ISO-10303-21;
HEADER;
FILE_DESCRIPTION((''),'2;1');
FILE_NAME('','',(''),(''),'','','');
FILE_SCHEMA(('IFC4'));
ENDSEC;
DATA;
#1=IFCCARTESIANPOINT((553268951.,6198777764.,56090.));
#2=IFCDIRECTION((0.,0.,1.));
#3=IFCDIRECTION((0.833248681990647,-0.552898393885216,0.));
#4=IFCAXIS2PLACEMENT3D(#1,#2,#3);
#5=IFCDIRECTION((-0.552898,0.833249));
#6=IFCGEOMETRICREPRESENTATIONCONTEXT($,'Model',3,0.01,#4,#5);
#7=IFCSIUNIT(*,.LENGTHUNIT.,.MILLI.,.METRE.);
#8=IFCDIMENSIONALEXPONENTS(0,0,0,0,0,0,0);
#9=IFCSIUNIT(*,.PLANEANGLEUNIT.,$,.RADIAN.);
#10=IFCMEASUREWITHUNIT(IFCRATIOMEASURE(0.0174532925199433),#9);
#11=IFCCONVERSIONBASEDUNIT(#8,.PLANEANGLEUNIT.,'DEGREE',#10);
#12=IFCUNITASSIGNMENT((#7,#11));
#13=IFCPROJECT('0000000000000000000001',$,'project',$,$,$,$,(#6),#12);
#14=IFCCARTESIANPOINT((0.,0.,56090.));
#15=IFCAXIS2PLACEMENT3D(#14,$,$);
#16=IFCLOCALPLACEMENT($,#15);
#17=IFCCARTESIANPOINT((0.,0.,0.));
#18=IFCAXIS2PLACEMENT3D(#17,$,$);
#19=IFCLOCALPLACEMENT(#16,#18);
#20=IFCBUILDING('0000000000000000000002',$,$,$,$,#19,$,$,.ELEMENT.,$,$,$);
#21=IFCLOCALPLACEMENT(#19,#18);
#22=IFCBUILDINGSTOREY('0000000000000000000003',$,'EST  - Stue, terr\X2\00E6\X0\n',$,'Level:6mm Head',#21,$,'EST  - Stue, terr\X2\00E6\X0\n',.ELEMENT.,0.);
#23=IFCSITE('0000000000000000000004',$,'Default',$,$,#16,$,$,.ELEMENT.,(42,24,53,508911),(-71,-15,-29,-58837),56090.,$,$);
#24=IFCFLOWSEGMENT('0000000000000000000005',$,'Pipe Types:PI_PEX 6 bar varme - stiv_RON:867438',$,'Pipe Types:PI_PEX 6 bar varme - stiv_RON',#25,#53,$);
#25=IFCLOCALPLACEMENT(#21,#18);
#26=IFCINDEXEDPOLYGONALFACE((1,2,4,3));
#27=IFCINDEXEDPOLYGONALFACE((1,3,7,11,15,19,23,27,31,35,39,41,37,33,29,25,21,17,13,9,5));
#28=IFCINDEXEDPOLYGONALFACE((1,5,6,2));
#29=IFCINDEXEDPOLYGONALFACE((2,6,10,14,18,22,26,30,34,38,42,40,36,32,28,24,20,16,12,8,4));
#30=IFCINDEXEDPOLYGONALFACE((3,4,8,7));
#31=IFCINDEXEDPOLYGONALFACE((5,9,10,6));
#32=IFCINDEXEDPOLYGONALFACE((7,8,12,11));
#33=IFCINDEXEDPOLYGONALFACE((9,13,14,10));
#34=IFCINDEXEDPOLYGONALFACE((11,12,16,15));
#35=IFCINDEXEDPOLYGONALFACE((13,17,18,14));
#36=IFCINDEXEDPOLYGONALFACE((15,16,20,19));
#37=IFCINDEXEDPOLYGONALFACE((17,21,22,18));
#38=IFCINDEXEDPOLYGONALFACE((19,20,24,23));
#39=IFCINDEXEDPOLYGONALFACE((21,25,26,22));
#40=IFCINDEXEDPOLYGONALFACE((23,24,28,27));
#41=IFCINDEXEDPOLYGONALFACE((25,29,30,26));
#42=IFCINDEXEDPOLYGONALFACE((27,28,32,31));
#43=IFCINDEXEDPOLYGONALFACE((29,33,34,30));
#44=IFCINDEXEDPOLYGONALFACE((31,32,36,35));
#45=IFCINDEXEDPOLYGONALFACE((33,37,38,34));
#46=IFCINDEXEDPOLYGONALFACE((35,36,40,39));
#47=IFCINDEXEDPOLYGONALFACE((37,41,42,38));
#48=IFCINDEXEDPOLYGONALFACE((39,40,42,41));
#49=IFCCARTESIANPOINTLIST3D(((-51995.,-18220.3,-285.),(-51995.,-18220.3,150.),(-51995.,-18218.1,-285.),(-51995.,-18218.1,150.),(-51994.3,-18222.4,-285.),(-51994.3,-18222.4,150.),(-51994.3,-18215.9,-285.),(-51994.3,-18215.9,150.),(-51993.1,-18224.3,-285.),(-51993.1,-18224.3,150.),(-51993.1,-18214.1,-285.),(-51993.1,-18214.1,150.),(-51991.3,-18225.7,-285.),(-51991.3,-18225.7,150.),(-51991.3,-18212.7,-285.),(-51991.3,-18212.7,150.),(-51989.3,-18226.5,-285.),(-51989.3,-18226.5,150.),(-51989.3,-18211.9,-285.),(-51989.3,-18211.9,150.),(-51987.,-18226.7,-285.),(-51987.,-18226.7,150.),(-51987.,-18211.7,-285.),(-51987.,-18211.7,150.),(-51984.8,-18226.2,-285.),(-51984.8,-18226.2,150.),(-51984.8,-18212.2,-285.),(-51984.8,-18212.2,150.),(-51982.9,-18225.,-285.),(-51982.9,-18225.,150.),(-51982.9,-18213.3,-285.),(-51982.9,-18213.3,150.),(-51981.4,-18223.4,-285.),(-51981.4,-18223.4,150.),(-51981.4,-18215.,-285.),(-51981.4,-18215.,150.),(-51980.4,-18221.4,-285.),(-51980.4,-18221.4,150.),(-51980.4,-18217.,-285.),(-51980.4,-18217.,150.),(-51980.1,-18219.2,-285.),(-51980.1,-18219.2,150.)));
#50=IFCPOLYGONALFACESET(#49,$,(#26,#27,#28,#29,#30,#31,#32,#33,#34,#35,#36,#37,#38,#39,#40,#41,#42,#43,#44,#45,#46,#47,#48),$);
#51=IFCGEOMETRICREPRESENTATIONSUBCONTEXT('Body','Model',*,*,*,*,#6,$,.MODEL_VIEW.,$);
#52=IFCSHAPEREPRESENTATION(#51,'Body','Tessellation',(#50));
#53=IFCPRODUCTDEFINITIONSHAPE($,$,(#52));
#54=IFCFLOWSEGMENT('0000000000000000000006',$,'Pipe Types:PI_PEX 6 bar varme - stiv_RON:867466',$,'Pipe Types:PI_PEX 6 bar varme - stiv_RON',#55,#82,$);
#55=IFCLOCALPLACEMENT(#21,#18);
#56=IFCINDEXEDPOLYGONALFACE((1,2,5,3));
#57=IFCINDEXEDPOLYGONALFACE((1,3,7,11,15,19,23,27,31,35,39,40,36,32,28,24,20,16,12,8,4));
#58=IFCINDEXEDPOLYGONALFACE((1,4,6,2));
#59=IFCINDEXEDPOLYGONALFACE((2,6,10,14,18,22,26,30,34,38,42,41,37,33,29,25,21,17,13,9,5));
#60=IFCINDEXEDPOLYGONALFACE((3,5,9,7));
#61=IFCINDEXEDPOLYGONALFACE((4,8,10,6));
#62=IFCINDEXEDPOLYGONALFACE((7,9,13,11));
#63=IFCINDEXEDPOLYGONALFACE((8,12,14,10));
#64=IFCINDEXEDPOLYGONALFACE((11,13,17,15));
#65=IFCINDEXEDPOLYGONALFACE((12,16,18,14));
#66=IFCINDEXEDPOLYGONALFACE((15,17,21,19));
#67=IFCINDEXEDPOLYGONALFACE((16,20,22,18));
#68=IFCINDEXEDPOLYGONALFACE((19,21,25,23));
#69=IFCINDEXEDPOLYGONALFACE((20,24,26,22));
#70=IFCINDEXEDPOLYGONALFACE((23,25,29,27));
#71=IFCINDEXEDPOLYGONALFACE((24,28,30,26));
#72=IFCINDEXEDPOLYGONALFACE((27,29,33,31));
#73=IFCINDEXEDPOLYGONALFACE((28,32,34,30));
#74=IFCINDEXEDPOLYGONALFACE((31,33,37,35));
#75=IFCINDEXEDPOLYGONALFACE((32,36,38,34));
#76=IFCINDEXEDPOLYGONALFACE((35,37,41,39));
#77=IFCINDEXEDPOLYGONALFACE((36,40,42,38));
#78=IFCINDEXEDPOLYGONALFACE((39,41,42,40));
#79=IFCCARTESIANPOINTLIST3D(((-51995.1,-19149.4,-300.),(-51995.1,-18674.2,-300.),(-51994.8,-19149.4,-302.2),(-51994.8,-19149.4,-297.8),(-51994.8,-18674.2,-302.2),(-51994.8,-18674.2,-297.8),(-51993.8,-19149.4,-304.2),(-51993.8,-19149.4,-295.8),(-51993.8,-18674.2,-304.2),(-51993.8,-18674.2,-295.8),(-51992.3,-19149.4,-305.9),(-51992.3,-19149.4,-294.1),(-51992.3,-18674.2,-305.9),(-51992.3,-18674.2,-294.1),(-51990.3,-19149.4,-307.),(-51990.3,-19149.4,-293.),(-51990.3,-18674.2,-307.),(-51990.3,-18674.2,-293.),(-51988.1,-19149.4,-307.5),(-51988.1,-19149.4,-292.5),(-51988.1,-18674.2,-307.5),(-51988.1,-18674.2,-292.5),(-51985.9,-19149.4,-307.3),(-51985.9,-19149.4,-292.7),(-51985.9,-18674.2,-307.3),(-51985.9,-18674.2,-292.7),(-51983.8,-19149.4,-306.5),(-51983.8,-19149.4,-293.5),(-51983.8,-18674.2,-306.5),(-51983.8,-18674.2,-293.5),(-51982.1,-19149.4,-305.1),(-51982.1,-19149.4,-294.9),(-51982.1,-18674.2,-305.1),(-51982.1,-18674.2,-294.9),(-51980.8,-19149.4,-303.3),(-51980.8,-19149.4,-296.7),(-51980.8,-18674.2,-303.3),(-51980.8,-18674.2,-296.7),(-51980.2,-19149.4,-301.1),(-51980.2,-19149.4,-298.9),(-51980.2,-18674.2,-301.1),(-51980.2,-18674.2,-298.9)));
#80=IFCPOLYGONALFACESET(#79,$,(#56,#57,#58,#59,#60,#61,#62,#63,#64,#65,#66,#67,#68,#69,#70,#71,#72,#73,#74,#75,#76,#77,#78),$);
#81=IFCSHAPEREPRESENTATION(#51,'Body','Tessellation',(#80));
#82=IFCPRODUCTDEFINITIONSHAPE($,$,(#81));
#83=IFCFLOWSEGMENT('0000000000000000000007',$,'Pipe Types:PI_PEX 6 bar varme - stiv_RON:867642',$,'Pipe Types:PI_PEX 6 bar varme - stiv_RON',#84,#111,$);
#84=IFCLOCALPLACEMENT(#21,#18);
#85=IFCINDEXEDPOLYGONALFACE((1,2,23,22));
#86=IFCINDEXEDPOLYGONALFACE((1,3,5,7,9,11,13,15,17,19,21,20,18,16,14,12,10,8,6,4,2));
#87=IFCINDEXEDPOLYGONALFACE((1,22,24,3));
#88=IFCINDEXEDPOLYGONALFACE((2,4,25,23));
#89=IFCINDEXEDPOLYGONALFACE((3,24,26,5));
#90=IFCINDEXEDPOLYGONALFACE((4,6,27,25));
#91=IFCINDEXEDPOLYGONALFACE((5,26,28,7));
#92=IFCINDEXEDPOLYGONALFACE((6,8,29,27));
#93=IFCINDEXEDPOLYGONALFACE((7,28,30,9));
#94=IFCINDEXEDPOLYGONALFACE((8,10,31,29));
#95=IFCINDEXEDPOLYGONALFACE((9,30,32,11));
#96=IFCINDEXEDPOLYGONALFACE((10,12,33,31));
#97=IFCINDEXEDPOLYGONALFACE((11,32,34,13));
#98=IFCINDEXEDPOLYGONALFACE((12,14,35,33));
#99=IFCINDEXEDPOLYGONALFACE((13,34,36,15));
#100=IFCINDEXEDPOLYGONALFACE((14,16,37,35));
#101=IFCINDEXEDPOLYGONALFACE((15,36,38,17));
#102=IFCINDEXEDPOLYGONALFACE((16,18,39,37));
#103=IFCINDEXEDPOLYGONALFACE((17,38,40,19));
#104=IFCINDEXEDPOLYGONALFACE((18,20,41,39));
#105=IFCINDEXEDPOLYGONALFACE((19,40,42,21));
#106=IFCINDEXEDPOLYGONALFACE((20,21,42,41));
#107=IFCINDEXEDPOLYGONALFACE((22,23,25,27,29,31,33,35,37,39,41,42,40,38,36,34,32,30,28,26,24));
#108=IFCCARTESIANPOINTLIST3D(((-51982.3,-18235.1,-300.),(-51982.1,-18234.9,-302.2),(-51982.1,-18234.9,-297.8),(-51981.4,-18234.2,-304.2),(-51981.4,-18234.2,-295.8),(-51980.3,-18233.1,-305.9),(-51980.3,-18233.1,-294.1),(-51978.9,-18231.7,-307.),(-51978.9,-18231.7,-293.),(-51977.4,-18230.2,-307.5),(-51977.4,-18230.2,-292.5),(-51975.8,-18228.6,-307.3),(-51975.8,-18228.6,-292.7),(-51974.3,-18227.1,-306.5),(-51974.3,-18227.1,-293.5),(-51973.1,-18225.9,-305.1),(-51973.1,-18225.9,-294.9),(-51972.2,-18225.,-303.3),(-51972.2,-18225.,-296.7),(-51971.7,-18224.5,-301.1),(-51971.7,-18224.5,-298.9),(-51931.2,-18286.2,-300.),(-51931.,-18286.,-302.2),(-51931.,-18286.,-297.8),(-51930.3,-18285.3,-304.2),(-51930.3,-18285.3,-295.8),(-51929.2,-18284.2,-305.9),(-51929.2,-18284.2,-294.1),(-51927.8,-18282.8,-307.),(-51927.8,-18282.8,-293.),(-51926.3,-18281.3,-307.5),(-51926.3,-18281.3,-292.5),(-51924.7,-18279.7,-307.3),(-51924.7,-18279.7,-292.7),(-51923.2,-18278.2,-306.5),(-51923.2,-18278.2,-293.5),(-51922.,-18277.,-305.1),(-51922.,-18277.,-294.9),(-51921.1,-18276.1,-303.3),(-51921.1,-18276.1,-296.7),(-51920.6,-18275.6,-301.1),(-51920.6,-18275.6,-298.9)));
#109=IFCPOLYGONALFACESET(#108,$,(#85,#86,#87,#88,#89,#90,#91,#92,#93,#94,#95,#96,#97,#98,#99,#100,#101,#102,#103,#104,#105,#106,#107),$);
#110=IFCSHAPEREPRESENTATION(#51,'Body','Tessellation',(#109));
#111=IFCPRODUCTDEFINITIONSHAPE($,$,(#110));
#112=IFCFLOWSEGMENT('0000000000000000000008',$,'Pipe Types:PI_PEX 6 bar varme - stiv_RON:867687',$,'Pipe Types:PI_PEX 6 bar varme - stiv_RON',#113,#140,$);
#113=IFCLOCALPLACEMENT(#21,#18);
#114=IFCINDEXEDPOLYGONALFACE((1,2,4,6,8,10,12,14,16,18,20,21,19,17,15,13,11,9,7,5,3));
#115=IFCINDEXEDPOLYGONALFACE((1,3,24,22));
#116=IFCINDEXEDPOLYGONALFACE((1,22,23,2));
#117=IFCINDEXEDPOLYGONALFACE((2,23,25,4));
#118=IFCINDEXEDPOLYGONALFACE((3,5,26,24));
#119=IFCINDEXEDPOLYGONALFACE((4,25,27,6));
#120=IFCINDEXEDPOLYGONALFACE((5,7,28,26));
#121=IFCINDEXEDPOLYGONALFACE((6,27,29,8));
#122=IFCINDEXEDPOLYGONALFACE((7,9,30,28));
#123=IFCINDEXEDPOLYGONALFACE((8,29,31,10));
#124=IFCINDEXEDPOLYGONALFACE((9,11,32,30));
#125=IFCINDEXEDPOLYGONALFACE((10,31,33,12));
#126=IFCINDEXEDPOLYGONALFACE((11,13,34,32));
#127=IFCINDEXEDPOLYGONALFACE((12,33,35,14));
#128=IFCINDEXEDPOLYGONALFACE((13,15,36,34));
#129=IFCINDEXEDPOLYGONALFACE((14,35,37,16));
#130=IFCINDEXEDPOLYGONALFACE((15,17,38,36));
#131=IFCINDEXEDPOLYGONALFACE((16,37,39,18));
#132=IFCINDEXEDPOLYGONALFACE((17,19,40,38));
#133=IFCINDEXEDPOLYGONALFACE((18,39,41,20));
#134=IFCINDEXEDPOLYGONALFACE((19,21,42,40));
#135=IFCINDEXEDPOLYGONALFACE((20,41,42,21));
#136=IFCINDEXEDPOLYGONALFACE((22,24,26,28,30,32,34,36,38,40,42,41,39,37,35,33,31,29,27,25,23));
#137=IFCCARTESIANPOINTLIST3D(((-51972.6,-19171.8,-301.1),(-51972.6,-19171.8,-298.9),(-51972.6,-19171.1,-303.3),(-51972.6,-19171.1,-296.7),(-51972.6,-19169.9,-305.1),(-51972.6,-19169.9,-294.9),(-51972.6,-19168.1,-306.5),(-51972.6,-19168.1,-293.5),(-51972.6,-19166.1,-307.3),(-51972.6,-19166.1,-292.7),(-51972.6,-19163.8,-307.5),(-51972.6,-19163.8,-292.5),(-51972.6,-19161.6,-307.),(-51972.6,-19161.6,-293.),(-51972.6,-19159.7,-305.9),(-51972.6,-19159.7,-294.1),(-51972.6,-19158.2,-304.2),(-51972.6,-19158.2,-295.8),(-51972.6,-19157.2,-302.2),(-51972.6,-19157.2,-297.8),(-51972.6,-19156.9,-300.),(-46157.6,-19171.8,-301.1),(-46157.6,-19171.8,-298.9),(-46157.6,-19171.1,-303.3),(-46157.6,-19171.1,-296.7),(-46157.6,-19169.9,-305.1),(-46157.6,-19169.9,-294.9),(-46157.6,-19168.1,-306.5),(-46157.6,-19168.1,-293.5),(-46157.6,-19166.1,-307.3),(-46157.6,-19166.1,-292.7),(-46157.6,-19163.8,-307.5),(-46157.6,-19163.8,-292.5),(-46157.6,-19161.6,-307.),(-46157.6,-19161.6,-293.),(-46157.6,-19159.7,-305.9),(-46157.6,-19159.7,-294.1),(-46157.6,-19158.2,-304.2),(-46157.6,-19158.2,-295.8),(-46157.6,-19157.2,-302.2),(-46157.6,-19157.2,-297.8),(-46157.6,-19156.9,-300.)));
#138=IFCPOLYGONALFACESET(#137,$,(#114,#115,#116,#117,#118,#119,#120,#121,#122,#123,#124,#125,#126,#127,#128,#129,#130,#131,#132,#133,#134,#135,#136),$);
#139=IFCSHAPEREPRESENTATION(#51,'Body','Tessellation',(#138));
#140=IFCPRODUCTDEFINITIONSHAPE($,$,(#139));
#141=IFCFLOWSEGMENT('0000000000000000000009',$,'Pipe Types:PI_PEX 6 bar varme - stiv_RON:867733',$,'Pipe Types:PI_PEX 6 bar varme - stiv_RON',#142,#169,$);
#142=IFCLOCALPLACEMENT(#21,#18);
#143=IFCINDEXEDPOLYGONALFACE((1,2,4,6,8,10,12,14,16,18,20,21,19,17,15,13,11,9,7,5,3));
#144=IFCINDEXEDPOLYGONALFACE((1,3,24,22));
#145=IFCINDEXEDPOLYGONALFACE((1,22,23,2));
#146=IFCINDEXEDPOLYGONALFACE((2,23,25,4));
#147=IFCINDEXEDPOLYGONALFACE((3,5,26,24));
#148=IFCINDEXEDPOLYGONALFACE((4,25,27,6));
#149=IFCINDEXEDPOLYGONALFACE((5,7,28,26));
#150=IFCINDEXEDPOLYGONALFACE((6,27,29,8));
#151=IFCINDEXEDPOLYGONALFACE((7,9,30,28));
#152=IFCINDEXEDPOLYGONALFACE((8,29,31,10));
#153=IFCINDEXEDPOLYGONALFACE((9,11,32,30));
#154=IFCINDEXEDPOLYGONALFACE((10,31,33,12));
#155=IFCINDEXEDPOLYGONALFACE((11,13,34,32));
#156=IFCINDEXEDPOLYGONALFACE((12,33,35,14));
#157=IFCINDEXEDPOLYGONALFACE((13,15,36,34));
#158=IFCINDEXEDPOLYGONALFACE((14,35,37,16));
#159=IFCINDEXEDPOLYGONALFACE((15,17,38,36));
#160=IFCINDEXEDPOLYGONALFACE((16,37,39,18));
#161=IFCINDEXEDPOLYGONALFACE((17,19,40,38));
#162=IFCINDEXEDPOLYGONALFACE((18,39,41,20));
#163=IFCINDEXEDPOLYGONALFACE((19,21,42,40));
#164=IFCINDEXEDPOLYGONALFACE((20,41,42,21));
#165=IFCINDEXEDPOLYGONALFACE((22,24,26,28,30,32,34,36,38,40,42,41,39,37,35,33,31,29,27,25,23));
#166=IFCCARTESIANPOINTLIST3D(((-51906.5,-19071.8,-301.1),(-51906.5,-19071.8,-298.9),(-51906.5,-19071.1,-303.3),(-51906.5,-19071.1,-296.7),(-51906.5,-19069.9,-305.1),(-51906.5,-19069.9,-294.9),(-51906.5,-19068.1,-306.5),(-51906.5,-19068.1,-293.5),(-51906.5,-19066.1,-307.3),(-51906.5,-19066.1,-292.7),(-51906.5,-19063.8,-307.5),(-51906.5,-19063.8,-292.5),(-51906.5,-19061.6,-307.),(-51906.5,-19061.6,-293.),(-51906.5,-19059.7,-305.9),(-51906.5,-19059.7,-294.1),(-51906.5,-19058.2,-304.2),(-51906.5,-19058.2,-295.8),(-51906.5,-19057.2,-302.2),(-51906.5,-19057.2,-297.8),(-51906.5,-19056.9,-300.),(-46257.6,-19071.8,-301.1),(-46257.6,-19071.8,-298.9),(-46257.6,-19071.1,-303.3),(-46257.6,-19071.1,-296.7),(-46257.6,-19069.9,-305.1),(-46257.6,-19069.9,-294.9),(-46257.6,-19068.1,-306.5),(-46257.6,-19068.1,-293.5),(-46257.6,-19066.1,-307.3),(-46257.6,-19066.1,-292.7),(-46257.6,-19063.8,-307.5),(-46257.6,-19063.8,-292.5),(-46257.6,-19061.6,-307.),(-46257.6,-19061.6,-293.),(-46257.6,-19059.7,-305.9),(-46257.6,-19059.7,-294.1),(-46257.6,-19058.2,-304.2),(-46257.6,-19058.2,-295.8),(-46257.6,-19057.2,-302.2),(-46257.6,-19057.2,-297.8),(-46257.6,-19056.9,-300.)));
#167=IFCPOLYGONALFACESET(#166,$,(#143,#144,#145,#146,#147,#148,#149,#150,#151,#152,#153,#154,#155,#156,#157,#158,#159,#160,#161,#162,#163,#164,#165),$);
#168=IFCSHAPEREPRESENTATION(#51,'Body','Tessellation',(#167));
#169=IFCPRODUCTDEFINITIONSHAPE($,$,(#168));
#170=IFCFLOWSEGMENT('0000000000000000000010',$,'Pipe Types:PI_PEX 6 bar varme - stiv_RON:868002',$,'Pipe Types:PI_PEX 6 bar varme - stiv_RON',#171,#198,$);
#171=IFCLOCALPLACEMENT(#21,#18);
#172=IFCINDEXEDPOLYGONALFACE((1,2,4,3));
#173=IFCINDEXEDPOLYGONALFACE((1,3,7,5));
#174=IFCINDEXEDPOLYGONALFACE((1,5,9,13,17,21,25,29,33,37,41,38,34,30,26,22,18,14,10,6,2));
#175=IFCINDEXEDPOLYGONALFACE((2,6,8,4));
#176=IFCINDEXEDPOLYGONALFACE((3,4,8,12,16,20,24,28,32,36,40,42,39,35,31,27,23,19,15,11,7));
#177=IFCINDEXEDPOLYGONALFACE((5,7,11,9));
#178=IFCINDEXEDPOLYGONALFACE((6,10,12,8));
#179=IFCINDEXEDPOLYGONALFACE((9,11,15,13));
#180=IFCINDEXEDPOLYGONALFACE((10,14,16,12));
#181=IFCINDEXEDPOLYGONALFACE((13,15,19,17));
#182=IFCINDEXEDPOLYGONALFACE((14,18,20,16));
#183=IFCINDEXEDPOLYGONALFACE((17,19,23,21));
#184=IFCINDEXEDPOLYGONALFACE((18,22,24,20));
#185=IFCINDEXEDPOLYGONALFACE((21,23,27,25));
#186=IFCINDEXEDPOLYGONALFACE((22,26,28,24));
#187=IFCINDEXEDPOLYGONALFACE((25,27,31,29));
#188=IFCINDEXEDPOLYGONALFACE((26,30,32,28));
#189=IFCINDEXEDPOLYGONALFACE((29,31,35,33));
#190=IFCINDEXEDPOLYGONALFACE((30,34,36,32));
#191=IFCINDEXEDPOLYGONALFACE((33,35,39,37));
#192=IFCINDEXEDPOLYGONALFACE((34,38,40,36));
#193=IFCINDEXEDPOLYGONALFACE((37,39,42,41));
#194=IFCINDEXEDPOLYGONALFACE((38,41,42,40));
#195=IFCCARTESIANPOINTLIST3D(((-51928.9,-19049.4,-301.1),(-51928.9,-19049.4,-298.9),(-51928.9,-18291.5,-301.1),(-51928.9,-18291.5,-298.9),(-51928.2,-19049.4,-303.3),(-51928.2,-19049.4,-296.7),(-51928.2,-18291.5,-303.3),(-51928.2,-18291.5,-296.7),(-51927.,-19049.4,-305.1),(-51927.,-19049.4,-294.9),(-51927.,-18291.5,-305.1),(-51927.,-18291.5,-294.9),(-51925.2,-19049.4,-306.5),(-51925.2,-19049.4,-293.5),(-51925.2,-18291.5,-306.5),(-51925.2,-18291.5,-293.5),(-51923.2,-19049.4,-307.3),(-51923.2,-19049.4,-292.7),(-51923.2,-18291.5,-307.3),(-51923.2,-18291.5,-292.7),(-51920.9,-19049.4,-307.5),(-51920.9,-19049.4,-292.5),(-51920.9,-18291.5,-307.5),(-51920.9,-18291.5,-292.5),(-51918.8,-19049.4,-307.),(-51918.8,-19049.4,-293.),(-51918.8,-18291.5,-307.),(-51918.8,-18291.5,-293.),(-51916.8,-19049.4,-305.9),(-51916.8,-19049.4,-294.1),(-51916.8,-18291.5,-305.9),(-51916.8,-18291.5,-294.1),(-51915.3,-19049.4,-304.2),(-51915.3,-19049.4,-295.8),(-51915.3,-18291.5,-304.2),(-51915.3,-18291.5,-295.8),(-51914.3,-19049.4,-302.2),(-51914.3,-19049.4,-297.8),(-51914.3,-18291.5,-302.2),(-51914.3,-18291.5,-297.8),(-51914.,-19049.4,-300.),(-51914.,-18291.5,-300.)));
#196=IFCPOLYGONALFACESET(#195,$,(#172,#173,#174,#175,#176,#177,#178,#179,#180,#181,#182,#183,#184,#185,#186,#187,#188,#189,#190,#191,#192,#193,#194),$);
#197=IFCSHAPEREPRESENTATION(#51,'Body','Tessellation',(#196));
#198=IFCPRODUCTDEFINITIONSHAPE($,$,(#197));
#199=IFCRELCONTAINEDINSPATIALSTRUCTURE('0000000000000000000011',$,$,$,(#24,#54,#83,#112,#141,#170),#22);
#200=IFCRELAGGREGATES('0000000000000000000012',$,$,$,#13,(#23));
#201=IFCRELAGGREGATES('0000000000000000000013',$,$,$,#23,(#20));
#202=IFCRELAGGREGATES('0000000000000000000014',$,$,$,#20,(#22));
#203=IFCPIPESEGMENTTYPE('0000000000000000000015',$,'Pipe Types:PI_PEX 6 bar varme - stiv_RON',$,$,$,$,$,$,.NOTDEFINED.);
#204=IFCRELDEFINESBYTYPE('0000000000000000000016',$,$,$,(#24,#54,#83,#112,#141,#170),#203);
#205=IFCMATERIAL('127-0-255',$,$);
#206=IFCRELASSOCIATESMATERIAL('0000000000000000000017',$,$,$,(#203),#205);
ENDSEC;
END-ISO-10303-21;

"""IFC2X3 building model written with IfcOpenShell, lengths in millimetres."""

from ifc_helpers import new_model, entity, si_unit, converted_unit, direction, frame, frame_2d, origin, origin_2d_with_axis, place, context, subcontext, project, spatial, circle, extrude, material, type_object, element, save


model = new_model("IFC2X3")

# Units and contexts
model_context = context("Model", 3, precision=0.01, world=frame((553268951.0, 6198777764.0, 56090.0), z_axis=(0.0, 0.0, 1.0), x_axis=(0.833248681990647, -0.552898393885216, 0.0)), true_north=direction((-0.552898, 0.833249)))
body_context = subcontext(model_context, "Body", "Model", "MODEL_VIEW")
ifc_project = project(units=[si_unit("LENGTHUNIT", "METRE", prefix="MILLI"), converted_unit("PLANEANGLEUNIT", "DEGREE", entity("IfcRatioMeasure", 0.0174532925199433), si_unit("PLANEANGLEUNIT", "RADIAN"), dimensions=[0, 0, 0, 0, 0, 0, 0])], contexts=[model_context])

# Site, building, storey
site_placement = place(None, frame((0.0, 0.0, 56090.0)))
site = spatial("IfcSite", under=ifc_project, at=site_placement, Name="Default", CompositionType="ELEMENT", RefLatitude=(42, 24, 53, 508911), RefLongitude=(-71, -15, -29, -58837), RefElevation=56090.0)
building_placement = place(site_placement, origin())
building = spatial("IfcBuilding", under=site, at=building_placement, CompositionType="ELEMENT")
storey_placement = place(building_placement, frame((0.0, 0.0, 0.0)))
storey = spatial("IfcBuildingStorey", under=building, at=storey_placement, Name="EST  - Stue, terræn", ObjectType="Level:6mm Head", LongName="EST  - Stue, terræn", CompositionType="ELEMENT", Elevation=0.0)

# Flow segments
ifc_material = material(Name="127-0-255")
pipe_segment_type = type_object("IfcPipeSegmentType", Name="Pipe Types:PI_PEX 6 bar varme - stiv_RON", PredefinedType="NOTDEFINED", material=ifc_material)
flow_segment_1_placement = place(storey_placement, origin())
element("IfcFlowSegment", 1, at=flow_segment_1_placement, inside=storey, type_object=pipe_segment_type, Name="Pipe Types:PI_PEX 6 bar varme - stiv_RON:867438", ObjectType="Pipe Types:PI_PEX 6 bar varme - stiv_RON", context=body_context, shape_type="SweptSolid", body=[
    extrude(circle(Radius=7.5, at=origin_2d_with_axis()), frame((-51987.6, -18219.2, -285.0)), (0.0, 0.0, 1.0), 435.0),
])
flow_segment_2_placement = place(storey_placement, origin())
element("IfcFlowSegment", 2, at=flow_segment_2_placement, inside=storey, type_object=pipe_segment_type, Name="Pipe Types:PI_PEX 6 bar varme - stiv_RON:867466", ObjectType="Pipe Types:PI_PEX 6 bar varme - stiv_RON", context=body_context, shape_type="SweptSolid", body=[
    extrude(circle(Radius=7.5, at=frame_2d((0.0, 0.0), x_axis=(1.0, 0.0))), frame((-51987.6, -19149.4, -300.0), z_axis=(0.0, 1.0, 0.0), x_axis=(-1.0, 0.0, 0.0)), (0.0, 0.0, 1.0), 475.2),
])
flow_segment_3_placement = place(storey_placement, origin())
element("IfcFlowSegment", 3, at=flow_segment_3_placement, inside=storey, type_object=pipe_segment_type, Name="Pipe Types:PI_PEX 6 bar varme - stiv_RON:867642", ObjectType="Pipe Types:PI_PEX 6 bar varme - stiv_RON", context=body_context, shape_type="SweptSolid", body=[
    extrude(circle(Radius=7.5, at=origin_2d_with_axis()), frame((-51977.0, -18229.8, -300.0), z_axis=(0.707107, -0.707107, 0.0), x_axis=(-0.707107, -0.707107, 0.0)), (0.0, 0.0, 1.0), 72.3),
])
flow_segment_4_placement = place(storey_placement, origin())
element("IfcFlowSegment", 4, at=flow_segment_4_placement, inside=storey, type_object=pipe_segment_type, Name="Pipe Types:PI_PEX 6 bar varme - stiv_RON:867687", ObjectType="Pipe Types:PI_PEX 6 bar varme - stiv_RON", context=body_context, shape_type="SweptSolid", body=[
    extrude(circle(Radius=7.5, at=frame_2d((0.0, 0.0), x_axis=(1.0, 0.0))), frame((-51972.6, -19164.4, -300.0), z_axis=(1.0, 0.0, 0.0), x_axis=(0.0, 1.0, 0.0)), (0.0, 0.0, 1.0), 5815.0),
])
flow_segment_5_placement = place(storey_placement, origin())
element("IfcFlowSegment", 5, at=flow_segment_5_placement, inside=storey, type_object=pipe_segment_type, Name="Pipe Types:PI_PEX 6 bar varme - stiv_RON:867733", ObjectType="Pipe Types:PI_PEX 6 bar varme - stiv_RON", context=body_context, shape_type="SweptSolid", body=[
    extrude(circle(Radius=7.5, at=origin_2d_with_axis()), frame((-51906.5, -19064.4, -300.0), z_axis=(1.0, 0.0, 0.0), x_axis=(0.0, 1.0, 0.0)), (0.0, 0.0, 1.0), 5648.9),
])
flow_segment_6_placement = place(storey_placement, origin())
element("IfcFlowSegment", 6, at=flow_segment_6_placement, inside=storey, type_object=pipe_segment_type, Name="Pipe Types:PI_PEX 6 bar varme - stiv_RON:868002", ObjectType="Pipe Types:PI_PEX 6 bar varme - stiv_RON", context=body_context, shape_type="SweptSolid", body=[
    extrude(circle(Radius=7.5, at=origin_2d_with_axis()), frame((-51921.5, -19049.4, -300.0), z_axis=(0.0, 1.0, 0.0), x_axis=(1.0, 0.0, 0.0)), (0.0, 0.0, 1.0), 757.9),
])

save(model, "model.ifc")
